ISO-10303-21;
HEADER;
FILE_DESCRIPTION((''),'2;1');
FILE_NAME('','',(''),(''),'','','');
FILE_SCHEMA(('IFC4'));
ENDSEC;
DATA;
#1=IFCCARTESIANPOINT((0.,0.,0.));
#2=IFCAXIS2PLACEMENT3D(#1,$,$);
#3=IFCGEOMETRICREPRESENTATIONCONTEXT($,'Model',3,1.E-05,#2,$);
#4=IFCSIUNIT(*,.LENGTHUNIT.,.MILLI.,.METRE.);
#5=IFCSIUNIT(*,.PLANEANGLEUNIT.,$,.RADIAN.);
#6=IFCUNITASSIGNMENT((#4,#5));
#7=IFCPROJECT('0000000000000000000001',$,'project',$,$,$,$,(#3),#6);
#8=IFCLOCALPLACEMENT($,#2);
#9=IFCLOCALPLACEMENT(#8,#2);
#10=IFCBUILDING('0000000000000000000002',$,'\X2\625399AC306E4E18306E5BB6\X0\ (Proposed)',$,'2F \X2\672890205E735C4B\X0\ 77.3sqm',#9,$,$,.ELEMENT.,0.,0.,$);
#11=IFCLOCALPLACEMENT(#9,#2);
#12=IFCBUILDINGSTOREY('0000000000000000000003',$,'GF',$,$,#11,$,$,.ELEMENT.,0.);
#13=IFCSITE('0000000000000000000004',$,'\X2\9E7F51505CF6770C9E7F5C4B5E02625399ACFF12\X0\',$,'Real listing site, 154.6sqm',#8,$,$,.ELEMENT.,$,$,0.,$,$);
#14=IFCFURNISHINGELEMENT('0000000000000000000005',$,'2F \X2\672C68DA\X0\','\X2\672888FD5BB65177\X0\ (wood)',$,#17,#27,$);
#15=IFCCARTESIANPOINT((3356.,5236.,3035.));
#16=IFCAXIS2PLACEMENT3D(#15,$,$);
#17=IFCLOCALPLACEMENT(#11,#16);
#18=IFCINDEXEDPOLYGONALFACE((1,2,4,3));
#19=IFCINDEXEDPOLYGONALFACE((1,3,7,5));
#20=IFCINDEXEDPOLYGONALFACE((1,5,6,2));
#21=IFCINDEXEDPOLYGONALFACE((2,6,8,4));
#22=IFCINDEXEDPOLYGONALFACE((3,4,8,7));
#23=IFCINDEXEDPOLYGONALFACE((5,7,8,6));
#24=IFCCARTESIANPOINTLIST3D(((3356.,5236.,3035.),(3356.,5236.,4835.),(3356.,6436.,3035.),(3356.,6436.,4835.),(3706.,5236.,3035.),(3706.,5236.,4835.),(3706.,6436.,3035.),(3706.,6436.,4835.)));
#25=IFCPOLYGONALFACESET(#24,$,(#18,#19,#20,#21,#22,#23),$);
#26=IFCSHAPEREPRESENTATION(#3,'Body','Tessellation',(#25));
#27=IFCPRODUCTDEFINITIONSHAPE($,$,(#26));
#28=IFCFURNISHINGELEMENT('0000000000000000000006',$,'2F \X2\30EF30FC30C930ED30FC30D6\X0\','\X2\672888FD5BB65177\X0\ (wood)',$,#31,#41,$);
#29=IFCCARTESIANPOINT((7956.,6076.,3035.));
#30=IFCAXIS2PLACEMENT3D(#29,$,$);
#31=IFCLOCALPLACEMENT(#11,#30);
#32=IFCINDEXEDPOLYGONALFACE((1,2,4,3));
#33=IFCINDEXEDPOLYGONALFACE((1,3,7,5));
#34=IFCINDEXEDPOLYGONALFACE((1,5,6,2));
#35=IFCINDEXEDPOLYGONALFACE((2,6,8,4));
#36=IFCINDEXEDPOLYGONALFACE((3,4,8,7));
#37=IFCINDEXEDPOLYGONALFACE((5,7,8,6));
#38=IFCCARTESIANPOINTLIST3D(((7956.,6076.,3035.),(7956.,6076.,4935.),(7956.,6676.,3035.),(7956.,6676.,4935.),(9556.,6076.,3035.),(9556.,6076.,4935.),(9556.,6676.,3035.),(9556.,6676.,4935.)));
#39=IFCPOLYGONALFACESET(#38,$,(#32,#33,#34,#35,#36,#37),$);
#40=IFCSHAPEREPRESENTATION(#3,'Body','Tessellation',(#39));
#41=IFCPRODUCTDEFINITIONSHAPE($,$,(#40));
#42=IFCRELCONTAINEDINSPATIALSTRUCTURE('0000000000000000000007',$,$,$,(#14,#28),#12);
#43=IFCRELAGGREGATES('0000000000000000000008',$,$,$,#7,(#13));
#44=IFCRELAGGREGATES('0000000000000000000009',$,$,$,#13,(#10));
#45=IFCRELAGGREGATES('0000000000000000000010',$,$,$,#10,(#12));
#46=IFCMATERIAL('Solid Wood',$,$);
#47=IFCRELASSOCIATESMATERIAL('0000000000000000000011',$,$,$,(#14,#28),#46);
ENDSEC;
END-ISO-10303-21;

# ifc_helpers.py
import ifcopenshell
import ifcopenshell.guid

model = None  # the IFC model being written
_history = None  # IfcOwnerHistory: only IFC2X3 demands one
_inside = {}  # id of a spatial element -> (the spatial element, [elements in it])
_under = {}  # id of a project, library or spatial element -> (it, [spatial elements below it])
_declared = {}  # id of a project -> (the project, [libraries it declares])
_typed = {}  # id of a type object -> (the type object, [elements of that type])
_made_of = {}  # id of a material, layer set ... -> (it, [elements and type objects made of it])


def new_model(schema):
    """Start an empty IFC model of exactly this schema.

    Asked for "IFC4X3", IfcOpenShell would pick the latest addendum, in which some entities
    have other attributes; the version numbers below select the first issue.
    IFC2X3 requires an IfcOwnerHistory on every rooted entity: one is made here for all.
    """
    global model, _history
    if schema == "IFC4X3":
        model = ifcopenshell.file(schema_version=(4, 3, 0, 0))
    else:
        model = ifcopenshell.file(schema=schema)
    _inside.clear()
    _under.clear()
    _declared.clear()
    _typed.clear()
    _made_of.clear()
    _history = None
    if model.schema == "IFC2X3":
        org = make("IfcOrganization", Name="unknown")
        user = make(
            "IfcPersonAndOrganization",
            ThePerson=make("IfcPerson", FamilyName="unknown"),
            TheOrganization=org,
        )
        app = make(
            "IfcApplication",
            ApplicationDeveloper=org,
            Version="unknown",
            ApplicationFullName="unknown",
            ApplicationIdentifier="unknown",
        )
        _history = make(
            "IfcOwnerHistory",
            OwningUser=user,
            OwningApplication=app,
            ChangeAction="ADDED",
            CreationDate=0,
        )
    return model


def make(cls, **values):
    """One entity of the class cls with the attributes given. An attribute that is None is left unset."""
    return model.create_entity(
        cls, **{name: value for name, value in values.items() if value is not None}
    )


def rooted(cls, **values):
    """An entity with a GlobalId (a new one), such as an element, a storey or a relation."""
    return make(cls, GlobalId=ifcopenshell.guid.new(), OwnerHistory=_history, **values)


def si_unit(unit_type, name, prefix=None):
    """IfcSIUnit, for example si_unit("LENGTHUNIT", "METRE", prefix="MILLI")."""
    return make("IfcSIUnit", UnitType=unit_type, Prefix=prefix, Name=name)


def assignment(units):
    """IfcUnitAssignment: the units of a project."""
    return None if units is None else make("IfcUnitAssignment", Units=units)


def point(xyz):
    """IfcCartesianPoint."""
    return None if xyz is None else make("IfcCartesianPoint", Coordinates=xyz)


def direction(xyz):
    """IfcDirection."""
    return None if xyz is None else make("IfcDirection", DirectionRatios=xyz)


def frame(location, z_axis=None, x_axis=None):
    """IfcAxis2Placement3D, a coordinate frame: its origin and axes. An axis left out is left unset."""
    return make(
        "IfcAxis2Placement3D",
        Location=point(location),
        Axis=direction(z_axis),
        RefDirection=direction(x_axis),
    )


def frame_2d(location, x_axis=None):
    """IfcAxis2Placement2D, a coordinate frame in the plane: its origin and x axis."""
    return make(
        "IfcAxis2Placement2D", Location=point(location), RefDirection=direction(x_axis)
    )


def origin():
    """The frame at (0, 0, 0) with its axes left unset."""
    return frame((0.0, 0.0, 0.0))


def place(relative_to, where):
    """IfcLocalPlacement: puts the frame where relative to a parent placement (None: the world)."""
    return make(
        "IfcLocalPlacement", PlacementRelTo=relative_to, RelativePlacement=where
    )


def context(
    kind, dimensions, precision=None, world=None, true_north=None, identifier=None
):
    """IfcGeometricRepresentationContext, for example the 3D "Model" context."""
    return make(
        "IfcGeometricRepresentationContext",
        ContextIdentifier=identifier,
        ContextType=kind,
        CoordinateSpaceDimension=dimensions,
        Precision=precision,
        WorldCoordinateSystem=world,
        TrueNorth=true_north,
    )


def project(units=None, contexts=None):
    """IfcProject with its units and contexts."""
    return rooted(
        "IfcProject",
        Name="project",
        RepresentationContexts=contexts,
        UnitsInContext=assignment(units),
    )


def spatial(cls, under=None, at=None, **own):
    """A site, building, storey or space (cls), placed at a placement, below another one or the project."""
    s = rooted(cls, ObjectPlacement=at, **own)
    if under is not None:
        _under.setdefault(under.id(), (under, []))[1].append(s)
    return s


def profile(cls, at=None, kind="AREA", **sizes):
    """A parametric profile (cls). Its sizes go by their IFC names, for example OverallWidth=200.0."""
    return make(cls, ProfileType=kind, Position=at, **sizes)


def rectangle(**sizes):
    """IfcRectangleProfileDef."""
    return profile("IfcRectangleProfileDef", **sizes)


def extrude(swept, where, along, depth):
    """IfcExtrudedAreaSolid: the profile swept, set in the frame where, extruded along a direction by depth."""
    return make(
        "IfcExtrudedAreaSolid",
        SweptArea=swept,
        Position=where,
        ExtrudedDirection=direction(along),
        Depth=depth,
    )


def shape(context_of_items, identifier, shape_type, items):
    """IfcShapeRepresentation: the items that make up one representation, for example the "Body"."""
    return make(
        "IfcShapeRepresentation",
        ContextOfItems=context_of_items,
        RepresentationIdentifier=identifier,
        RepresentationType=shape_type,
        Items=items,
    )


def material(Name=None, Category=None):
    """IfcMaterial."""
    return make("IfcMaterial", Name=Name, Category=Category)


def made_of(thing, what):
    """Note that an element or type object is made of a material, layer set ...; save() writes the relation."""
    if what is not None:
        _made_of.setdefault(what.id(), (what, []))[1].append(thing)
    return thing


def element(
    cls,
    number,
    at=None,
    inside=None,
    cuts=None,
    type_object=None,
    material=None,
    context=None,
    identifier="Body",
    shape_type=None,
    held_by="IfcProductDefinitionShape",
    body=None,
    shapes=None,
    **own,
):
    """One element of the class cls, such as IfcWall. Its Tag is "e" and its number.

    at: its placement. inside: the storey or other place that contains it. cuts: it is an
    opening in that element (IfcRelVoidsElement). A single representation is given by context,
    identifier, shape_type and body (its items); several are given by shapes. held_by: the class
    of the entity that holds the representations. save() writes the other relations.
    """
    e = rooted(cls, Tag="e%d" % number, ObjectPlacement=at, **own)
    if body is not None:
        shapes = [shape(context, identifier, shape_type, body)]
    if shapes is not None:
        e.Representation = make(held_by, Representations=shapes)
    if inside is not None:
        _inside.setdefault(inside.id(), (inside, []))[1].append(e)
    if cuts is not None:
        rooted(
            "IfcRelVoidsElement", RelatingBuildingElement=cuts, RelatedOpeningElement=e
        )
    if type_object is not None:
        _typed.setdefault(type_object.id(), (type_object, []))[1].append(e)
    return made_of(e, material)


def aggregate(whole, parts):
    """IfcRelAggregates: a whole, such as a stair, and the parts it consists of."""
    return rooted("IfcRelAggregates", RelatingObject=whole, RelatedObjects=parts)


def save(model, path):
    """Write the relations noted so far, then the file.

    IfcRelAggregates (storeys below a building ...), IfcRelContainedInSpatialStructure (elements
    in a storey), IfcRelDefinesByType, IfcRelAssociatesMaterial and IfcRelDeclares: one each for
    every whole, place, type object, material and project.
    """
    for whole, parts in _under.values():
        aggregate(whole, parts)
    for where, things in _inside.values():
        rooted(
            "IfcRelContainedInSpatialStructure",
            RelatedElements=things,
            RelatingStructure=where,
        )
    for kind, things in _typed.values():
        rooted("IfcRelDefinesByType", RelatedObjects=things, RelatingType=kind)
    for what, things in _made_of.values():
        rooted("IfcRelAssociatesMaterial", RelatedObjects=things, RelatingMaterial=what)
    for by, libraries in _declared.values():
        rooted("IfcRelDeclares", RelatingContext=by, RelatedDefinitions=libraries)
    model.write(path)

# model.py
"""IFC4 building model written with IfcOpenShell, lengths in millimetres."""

from ifc_helpers import new_model, si_unit, frame, frame_2d, origin, place, context, project, spatial, rectangle, extrude, material, element, save


model = new_model("IFC4")

# Units and contexts
model_context = context("Model", 3, precision=1e-05, world=origin())
ifc_project = project(units=[si_unit("LENGTHUNIT", "METRE", prefix="MILLI"), si_unit("PLANEANGLEUNIT", "RADIAN")], contexts=[model_context])

# Site, building, storey
site_placement = place(None, origin())
site = spatial("IfcSite", under=ifc_project, at=site_placement, Name="鹿児島県鹿屋市打馬２", ObjectType="Real listing site, 154.6sqm", CompositionType="ELEMENT", RefElevation=0.0)
building_placement = place(site_placement, origin())
building = spatial("IfcBuilding", under=site, at=building_placement, Name="打馬の丘の家 (Proposed)", ObjectType="2F 木造平屋 77.3sqm", CompositionType="ELEMENT", ElevationOfRefHeight=0.0, ElevationOfTerrain=0.0)
storey_placement = place(building_placement, origin())
storey = spatial("IfcBuildingStorey", under=building, at=storey_placement, Name="GF", CompositionType="ELEMENT", Elevation=0.0)

# Shared definitions
ifc_material_1 = material(Name="Solid Wood")

# Furnishing elements
furnishing_1_placement = place(storey_placement, frame((3356.0, 5236.0, 3035.0)))
element("IfcFurnishingElement", 1, at=furnishing_1_placement, inside=storey, material=ifc_material_1, Name="2F 本棚", Description="木製家具 (wood)", context=model_context, shape_type="SweptSolid", body=[
    extrude(rectangle(XDim=350.0, YDim=1200.0, at=frame_2d((175.0, 600.0))), frame((3356.0, 5236.0, 3035.0)), (0.0, 0.0, 1.0), 1800.0),
])
furnishing_2_placement = place(storey_placement, frame((7956.0, 6076.0, 3035.0)))
element("IfcFurnishingElement", 2, at=furnishing_2_placement, inside=storey, material=ifc_material_1, Name="2F ワードローブ", Description="木製家具 (wood)", context=model_context, shape_type="SweptSolid", body=[
    extrude(rectangle(XDim=1600.0, YDim=600.0, at=frame_2d((800.0, 300.0))), frame((7956.0, 6076.0, 3035.0)), (0.0, 0.0, 1.0), 1900.0),
])

save(model, "model.ifc")
